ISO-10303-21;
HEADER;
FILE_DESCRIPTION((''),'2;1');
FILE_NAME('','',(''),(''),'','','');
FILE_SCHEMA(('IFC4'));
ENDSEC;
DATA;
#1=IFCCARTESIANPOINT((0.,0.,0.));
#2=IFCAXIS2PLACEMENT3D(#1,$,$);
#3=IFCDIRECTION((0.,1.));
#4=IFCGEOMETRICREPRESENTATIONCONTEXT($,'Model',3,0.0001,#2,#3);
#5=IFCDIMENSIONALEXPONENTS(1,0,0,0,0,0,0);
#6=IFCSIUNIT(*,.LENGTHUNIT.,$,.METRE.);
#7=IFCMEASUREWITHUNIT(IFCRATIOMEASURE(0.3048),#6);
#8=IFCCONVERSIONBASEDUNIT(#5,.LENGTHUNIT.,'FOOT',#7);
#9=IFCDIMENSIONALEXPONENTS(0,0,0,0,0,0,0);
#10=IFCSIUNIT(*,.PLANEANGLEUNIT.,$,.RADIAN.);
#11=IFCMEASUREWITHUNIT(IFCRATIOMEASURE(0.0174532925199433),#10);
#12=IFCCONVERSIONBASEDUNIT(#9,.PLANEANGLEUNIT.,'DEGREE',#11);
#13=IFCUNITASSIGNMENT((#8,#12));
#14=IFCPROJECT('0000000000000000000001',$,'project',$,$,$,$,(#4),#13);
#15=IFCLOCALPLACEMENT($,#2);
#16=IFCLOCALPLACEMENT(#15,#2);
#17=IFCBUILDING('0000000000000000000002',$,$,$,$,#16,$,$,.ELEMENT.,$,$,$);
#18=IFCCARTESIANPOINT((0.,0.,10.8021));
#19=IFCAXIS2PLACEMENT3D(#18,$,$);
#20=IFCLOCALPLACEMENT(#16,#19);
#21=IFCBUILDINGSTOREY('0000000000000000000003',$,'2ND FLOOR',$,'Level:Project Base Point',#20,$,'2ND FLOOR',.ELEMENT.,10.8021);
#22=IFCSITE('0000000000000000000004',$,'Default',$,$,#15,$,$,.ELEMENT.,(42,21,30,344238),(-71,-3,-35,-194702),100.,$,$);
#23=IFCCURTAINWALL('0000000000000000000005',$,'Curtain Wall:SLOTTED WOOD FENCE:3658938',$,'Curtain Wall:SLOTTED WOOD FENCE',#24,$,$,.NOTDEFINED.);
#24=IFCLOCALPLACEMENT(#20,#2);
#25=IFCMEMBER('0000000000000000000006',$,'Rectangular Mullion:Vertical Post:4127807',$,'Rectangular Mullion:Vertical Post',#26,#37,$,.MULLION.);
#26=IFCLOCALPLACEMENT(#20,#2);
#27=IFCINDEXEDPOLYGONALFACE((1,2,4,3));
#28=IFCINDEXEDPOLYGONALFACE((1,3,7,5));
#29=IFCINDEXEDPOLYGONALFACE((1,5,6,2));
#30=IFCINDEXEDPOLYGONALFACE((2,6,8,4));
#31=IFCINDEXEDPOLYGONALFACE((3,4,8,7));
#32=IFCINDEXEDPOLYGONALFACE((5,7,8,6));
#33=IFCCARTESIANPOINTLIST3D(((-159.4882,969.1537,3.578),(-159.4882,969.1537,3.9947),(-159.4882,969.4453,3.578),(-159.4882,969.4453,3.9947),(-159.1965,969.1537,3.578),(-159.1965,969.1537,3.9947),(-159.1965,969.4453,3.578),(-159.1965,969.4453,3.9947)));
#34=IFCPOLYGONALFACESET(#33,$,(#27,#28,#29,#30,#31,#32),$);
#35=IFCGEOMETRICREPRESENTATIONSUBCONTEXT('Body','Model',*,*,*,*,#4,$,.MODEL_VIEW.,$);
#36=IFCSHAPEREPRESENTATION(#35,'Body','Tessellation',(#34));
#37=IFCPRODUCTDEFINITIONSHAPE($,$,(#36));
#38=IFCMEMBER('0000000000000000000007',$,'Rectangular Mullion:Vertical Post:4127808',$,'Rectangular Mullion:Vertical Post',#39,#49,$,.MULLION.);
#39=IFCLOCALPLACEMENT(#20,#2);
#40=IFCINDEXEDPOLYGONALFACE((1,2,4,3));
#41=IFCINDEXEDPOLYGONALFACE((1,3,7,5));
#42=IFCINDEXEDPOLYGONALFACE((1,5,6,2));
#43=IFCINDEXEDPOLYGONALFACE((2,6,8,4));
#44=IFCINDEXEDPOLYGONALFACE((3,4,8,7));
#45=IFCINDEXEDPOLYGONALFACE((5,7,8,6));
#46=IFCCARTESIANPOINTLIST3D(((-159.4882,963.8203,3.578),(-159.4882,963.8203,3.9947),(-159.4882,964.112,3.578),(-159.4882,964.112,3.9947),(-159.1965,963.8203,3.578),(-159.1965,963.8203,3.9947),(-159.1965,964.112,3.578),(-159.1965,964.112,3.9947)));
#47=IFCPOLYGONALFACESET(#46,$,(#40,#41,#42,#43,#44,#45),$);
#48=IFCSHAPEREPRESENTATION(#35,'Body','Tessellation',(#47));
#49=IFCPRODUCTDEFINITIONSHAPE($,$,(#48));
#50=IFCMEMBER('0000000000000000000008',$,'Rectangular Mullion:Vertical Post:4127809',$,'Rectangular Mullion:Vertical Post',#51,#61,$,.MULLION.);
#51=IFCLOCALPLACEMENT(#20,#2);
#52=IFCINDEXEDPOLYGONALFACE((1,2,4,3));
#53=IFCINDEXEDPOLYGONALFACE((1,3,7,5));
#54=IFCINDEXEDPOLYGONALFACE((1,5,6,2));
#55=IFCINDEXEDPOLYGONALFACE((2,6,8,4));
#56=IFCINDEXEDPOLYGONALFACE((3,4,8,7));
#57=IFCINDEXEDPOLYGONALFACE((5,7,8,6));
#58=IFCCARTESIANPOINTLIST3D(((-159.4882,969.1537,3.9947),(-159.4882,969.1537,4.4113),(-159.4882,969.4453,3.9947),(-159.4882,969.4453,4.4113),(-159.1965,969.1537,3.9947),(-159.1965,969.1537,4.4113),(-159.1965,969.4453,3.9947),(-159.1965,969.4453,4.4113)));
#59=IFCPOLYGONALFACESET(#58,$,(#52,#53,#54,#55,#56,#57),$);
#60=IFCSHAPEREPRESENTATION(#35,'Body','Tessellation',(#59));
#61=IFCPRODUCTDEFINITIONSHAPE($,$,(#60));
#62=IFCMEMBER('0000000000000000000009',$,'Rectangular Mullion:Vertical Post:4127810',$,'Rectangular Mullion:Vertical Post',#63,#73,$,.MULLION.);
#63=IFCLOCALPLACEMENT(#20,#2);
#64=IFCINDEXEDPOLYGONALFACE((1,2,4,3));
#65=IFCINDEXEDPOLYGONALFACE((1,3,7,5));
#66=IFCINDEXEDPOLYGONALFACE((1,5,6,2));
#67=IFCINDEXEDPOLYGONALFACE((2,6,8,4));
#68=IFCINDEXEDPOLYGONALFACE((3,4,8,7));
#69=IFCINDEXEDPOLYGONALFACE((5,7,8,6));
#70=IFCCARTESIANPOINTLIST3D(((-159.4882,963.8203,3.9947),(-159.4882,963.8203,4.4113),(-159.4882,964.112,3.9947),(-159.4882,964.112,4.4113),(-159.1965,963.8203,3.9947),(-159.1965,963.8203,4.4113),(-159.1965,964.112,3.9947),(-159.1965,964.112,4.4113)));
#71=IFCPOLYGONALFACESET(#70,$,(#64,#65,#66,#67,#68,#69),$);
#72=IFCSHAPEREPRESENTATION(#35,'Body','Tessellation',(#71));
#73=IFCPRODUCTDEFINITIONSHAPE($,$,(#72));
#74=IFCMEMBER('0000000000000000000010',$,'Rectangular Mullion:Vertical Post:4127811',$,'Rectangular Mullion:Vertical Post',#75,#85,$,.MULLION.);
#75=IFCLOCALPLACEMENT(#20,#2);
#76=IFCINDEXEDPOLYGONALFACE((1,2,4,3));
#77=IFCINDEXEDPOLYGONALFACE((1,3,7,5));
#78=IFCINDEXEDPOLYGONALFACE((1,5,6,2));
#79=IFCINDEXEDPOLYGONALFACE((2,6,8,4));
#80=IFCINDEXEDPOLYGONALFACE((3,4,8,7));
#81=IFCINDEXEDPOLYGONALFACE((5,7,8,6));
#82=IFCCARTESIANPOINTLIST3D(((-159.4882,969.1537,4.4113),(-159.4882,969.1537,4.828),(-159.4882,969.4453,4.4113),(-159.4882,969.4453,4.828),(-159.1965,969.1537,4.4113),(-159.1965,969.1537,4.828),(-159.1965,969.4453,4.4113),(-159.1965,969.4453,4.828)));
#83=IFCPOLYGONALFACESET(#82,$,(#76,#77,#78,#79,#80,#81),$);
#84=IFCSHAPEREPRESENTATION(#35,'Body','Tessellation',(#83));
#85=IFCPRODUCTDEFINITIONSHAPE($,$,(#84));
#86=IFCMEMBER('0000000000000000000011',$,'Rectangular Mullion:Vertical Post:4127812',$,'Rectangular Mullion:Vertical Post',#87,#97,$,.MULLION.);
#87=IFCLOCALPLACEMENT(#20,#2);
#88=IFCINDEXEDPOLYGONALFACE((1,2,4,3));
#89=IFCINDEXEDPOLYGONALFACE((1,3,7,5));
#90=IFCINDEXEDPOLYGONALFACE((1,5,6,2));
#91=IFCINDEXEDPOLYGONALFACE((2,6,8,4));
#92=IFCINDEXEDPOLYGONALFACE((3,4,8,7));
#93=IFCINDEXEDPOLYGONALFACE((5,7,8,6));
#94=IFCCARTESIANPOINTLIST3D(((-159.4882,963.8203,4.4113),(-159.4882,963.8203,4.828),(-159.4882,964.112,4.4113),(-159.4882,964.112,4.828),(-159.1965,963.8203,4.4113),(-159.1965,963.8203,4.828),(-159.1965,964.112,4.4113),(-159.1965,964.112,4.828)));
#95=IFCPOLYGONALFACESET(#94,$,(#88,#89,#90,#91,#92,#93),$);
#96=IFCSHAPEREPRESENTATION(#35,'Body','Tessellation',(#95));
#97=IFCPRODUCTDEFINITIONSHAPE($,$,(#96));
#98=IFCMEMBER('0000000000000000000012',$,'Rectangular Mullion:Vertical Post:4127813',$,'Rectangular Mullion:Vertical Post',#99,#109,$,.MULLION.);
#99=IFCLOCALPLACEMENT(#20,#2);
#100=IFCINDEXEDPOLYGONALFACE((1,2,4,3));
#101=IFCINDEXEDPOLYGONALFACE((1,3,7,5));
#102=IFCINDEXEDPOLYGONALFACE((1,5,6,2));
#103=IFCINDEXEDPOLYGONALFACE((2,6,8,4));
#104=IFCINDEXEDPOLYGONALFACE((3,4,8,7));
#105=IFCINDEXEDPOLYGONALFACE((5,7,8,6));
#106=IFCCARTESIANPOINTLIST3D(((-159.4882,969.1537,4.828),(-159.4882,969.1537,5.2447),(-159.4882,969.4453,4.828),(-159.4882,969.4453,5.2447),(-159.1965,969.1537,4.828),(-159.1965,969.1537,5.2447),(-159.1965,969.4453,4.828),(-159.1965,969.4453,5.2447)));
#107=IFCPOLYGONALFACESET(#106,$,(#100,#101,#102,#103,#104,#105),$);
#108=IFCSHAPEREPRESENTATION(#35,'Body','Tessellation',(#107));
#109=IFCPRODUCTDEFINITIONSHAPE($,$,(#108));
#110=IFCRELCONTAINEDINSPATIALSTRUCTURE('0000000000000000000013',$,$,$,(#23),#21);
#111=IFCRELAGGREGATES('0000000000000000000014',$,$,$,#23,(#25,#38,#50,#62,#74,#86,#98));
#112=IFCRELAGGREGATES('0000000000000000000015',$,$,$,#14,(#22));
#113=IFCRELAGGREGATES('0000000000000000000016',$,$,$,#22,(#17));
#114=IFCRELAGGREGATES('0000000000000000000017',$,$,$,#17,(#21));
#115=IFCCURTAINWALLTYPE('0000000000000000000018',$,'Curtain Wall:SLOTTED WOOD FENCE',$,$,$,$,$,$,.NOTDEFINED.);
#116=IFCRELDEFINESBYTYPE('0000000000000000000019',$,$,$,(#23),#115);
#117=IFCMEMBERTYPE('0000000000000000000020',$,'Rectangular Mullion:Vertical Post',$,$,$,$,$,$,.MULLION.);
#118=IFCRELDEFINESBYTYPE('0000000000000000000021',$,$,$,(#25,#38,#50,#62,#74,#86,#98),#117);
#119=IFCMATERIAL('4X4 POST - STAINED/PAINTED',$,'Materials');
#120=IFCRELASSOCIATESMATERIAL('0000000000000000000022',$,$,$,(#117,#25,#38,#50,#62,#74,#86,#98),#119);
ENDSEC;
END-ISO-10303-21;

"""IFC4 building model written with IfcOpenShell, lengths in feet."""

from ifc_helpers import new_model, entity, si_unit, converted_unit, direction, frame, origin, origin_2d_with_axis, place, context, subcontext, project, spatial, rectangle, extrude, source, transform, mapped, material, material_profile, profile_set, profile_usage, type_object, type_shapes, element, aggregate, save


model = new_model("IFC4")

# Units and contexts
model_context = context("Model", 3, precision=0.0001, world=origin(), true_north=direction((0.0, 1.0)))
body_context = subcontext(model_context, "Body", "Model", "MODEL_VIEW")
ifc_project = project(units=[converted_unit("LENGTHUNIT", "FOOT", entity("IfcRatioMeasure", 0.3048), si_unit("LENGTHUNIT", "METRE"), dimensions=[1, 0, 0, 0, 0, 0, 0]), converted_unit("PLANEANGLEUNIT", "DEGREE", entity("IfcRatioMeasure", 0.0174532925199433), si_unit("PLANEANGLEUNIT", "RADIAN"), dimensions=[0, 0, 0, 0, 0, 0, 0])], contexts=[model_context])

# Site, building, storey
site_placement = place(None, origin())
site = spatial("IfcSite", under=ifc_project, at=site_placement, Name="Default", CompositionType="ELEMENT", RefLatitude=(42, 21, 30, 344238), RefLongitude=(-71, -3, -35, -194702), RefElevation=100.0)
building_placement = place(site_placement, origin())
building = spatial("IfcBuilding", under=site, at=building_placement, CompositionType="ELEMENT")
storey_placement = place(building_placement, frame((0.0, 0.0, 10.8021)))
storey = spatial("IfcBuildingStorey", under=building, at=storey_placement, Name="2ND FLOOR", ObjectType="Level:Project Base Point", LongName="2ND FLOOR", CompositionType="ELEMENT", Elevation=10.8021)

# Curtain wall, members
curtain_wall_type = type_object("IfcCurtainWallType", Name="Curtain Wall:SLOTTED WOOD FENCE", PredefinedType="NOTDEFINED")
curtain_wall_placement = place(storey_placement, frame((0.0, 0.0, -10.8021)))
curtain_wall = element("IfcCurtainWall", 1, at=curtain_wall_placement, inside=storey, type_object=curtain_wall_type, Name="Curtain Wall:SLOTTED WOOD FENCE:3658938", ObjectType="Curtain Wall:SLOTTED WOOD FENCE", PredefinedType="NOTDEFINED")
ifc_material = material(Name="4X4 POST - STAINED/PAINTED", Category="Materials")
ifc_material_profile = material_profile(ifc_material, rectangle(XDim=0.2917, YDim=0.2917, at=origin_2d_with_axis()), Name="Vertical Post")
ifc_profile_set = profile_set([ifc_material_profile], Name="Vertical Post")
member_type_1 = type_object("IfcMemberType", Name="Rectangular Mullion:Vertical Post", PredefinedType="MULLION", material=ifc_profile_set)
shared_shape_1 = source(origin(), body_context, "Body", "SweptSolid", [
    extrude(rectangle(XDim=0.2917, YDim=0.2917, at=origin_2d_with_axis()), frame((0.0, -0.2083, -0.4167), z_axis=(0.0, 0.0, 1.0), x_axis=(0.0, -1.0, 0.0)), (0.0, 0.0, 1.0), 0.4167),
])
type_shapes(member_type_1, [shared_shape_1])
ifc_profile_usage_1 = profile_usage(ifc_profile_set)
member_1_placement = place(storey_placement, frame((-159.5507, 969.2995, 3.578), z_axis=(0.0, 0.0, -1.0), x_axis=(0.0, -1.0, 0.0)))
member_1 = element("IfcMember", 2, at=member_1_placement, type_object=member_type_1, material=ifc_profile_usage_1, Name="Rectangular Mullion:Vertical Post:4127807", ObjectType="Rectangular Mullion:Vertical Post", PredefinedType="MULLION", context=body_context, shape_type="MappedRepresentation", body=[
    mapped(shared_shape_1, transform((0.0, 0.0, 0.0), scale=1.0)),
])
ifc_profile_usage_2 = profile_usage(ifc_profile_set)
member_2_placement = place(storey_placement, frame((-159.5507, 963.9662, 3.578), z_axis=(0.0, 0.0, -1.0), x_axis=(0.0, -1.0, 0.0)))
member_2 = element("IfcMember", 3, at=member_2_placement, type_object=member_type_1, material=ifc_profile_usage_2, Name="Rectangular Mullion:Vertical Post:4127808", ObjectType="Rectangular Mullion:Vertical Post", PredefinedType="MULLION", context=body_context, shape_type="MappedRepresentation", body=[
    mapped(shared_shape_1, transform((0.0, 0.0, 0.0), scale=1.0)),
])
ifc_profile_usage_3 = profile_usage(ifc_profile_set)
member_3_placement = place(storey_placement, frame((-159.5507, 969.2995, 3.9947), z_axis=(0.0, 0.0, -1.0), x_axis=(0.0, -1.0, 0.0)))
member_3 = element("IfcMember", 4, at=member_3_placement, type_object=member_type_1, material=ifc_profile_usage_3, Name="Rectangular Mullion:Vertical Post:4127809", ObjectType="Rectangular Mullion:Vertical Post", PredefinedType="MULLION", context=body_context, shape_type="MappedRepresentation", body=[
    mapped(shared_shape_1, transform((0.0, 0.0, 0.0), scale=1.0)),
])
ifc_profile_usage_4 = profile_usage(ifc_profile_set)
member_4_placement = place(storey_placement, frame((-159.5507, 963.9662, 3.9947), z_axis=(0.0, 0.0, -1.0), x_axis=(0.0, -1.0, 0.0)))
member_4 = element("IfcMember", 5, at=member_4_placement, type_object=member_type_1, material=ifc_profile_usage_4, Name="Rectangular Mullion:Vertical Post:4127810", ObjectType="Rectangular Mullion:Vertical Post", PredefinedType="MULLION", context=body_context, shape_type="MappedRepresentation", body=[
    mapped(shared_shape_1, transform((0.0, 0.0, 0.0), scale=1.0)),
])
ifc_profile_usage_5 = profile_usage(ifc_profile_set)
member_5_placement = place(storey_placement, frame((-159.5507, 969.2995, 4.4113), z_axis=(0.0, 0.0, -1.0), x_axis=(0.0, -1.0, 0.0)))
member_5 = element("IfcMember", 6, at=member_5_placement, type_object=member_type_1, material=ifc_profile_usage_5, Name="Rectangular Mullion:Vertical Post:4127811", ObjectType="Rectangular Mullion:Vertical Post", PredefinedType="MULLION", context=body_context, shape_type="MappedRepresentation", body=[
    mapped(shared_shape_1, transform((0.0, 0.0, 0.0), scale=1.0)),
])
ifc_profile_usage_6 = profile_usage(ifc_profile_set)
member_6_placement = place(storey_placement, frame((-159.5507, 963.9662, 4.4113), z_axis=(0.0, 0.0, -1.0), x_axis=(0.0, -1.0, 0.0)))
member_6 = element("IfcMember", 7, at=member_6_placement, type_object=member_type_1, material=ifc_profile_usage_6, Name="Rectangular Mullion:Vertical Post:4127812", ObjectType="Rectangular Mullion:Vertical Post", PredefinedType="MULLION", context=body_context, shape_type="MappedRepresentation", body=[
    mapped(shared_shape_1, transform((0.0, 0.0, 0.0), scale=1.0)),
])
ifc_profile_usage_7 = profile_usage(ifc_profile_set)
member_7_placement = place(storey_placement, frame((-159.5507, 969.2995, 4.828), z_axis=(0.0, 0.0, -1.0), x_axis=(0.0, -1.0, 0.0)))
member_7 = element("IfcMember", 8, at=member_7_placement, type_object=member_type_1, material=ifc_profile_usage_7, Name="Rectangular Mullion:Vertical Post:4127813", ObjectType="Rectangular Mullion:Vertical Post", PredefinedType="MULLION", context=body_context, shape_type="MappedRepresentation", body=[
    mapped(shared_shape_1, transform((0.0, 0.0, 0.0), scale=1.0)),
])
aggregate(curtain_wall, [member_1, member_2, member_3, member_4, member_5, member_6, member_7])

save(model, "model.ifc")
